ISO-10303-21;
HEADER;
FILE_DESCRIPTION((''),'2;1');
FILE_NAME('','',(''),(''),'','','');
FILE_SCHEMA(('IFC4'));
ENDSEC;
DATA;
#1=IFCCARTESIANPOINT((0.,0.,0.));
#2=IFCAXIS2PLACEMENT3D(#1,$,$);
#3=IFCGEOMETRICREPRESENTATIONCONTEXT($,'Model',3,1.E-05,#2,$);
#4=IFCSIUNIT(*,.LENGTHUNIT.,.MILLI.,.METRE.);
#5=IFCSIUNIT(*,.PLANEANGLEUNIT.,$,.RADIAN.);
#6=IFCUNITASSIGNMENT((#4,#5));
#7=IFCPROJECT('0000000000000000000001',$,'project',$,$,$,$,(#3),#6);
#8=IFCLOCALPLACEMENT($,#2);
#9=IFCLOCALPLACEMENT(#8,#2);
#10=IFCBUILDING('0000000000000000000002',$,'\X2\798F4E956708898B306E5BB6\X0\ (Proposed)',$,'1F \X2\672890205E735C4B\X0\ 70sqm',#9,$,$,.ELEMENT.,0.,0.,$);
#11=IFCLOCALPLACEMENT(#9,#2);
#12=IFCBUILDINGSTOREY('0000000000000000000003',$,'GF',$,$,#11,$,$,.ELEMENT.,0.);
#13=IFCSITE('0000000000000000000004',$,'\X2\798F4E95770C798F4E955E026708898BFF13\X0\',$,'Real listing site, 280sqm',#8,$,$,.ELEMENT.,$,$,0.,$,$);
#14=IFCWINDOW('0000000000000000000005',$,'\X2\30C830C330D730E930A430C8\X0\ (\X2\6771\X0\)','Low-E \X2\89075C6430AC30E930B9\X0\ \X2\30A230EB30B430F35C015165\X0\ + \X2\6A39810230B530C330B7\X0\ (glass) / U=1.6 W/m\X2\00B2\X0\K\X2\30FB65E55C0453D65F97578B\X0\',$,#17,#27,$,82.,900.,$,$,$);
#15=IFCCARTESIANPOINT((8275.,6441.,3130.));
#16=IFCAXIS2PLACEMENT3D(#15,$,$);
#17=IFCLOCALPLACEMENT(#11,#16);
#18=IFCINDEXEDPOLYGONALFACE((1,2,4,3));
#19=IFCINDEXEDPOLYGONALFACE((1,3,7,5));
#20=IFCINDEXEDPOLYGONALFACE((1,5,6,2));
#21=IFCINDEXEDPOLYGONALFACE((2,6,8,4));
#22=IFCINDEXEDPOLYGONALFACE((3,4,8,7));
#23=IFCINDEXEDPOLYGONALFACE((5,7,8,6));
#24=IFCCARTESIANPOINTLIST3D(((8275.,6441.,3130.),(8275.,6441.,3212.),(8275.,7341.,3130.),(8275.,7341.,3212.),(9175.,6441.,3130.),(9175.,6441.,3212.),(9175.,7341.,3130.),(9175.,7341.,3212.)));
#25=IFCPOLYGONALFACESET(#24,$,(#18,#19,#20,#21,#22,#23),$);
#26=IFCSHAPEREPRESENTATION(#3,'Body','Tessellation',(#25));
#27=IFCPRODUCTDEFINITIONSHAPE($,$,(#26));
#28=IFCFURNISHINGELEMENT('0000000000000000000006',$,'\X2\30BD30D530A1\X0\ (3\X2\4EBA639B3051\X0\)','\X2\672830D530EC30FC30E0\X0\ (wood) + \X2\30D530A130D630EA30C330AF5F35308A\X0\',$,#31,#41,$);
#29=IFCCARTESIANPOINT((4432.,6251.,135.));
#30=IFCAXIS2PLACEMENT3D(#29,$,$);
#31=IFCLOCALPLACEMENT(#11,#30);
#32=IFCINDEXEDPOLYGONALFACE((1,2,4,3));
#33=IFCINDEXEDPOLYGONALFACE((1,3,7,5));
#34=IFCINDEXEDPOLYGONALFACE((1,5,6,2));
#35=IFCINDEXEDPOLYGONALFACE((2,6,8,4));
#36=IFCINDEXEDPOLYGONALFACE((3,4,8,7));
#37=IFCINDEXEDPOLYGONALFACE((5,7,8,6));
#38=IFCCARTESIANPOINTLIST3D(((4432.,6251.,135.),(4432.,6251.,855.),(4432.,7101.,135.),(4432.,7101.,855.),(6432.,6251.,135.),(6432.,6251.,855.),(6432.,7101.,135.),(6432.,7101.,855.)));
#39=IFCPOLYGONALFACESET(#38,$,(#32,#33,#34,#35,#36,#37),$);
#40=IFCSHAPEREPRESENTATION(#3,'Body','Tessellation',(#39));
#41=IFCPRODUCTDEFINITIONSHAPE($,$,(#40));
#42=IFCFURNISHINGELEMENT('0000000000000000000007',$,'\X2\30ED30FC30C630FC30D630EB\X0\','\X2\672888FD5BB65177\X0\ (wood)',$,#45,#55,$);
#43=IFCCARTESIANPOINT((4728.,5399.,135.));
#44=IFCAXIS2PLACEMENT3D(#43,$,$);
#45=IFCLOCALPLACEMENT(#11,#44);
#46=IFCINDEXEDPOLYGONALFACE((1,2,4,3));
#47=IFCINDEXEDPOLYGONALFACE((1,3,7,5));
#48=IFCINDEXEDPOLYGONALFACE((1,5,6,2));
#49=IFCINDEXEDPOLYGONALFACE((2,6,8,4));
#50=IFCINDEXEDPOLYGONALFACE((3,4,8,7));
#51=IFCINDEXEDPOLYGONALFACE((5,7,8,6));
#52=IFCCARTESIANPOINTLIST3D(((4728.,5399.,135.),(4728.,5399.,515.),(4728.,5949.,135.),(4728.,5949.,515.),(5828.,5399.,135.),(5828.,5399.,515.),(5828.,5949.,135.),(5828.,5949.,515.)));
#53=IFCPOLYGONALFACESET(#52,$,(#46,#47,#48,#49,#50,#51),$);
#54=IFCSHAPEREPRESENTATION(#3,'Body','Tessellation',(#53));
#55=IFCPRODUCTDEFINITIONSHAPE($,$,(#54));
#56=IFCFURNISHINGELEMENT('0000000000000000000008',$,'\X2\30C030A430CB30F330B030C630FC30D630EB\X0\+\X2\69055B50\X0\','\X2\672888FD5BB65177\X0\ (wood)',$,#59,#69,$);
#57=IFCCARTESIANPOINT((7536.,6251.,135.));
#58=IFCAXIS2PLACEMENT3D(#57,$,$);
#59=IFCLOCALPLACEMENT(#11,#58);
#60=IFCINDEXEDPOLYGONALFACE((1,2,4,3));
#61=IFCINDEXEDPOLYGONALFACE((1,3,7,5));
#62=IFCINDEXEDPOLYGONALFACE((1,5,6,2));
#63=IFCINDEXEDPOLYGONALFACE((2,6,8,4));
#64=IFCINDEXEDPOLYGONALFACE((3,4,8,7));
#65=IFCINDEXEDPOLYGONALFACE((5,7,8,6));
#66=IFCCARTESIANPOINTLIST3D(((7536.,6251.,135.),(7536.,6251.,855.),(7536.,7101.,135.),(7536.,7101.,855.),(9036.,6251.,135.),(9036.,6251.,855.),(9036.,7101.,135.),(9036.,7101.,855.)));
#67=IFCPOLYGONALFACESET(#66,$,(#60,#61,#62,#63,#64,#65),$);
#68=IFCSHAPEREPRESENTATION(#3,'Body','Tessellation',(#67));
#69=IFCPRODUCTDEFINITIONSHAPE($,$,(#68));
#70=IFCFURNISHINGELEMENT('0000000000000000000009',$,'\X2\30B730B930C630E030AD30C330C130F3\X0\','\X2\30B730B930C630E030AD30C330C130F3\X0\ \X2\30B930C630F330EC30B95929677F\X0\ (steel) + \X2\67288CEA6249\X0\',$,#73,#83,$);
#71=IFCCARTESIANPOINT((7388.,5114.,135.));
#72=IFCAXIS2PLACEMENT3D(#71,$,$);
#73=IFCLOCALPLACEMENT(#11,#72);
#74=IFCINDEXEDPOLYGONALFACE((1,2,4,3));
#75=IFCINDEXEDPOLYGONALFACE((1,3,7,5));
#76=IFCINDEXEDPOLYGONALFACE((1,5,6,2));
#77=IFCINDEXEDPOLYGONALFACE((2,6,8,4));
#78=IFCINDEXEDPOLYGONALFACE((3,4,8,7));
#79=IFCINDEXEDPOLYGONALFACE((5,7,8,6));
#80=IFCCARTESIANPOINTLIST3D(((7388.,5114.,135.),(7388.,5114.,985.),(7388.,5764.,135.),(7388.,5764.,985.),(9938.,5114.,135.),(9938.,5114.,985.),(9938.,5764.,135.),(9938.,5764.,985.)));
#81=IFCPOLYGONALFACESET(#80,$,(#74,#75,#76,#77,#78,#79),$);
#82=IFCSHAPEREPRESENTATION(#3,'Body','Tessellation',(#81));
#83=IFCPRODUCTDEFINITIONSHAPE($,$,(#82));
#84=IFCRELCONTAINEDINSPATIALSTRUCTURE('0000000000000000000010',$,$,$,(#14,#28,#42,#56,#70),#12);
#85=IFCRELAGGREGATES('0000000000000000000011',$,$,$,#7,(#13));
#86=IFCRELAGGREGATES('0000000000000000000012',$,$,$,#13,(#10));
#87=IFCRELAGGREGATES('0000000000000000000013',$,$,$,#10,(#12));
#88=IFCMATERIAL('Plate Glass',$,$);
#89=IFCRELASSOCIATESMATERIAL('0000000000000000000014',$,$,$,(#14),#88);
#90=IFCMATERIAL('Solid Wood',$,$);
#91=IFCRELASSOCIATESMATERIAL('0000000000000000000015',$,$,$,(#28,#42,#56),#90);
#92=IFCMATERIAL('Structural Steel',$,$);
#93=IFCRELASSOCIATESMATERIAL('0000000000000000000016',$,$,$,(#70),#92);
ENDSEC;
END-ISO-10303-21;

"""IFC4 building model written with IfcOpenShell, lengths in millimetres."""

from ifc_helpers import new_model, si_unit, frame, frame_2d, origin, place, context, project, spatial, rectangle, extrude, material, element, save


model = new_model("IFC4")

# Units and contexts
model_context = context("Model", 3, precision=1e-05, world=origin())
ifc_project = project(units=[si_unit("LENGTHUNIT", "METRE", prefix="MILLI"), si_unit("PLANEANGLEUNIT", "RADIAN")], contexts=[model_context])

# Site, building, storey
site_placement = place(None, origin())
site = spatial("IfcSite", under=ifc_project, at=site_placement, Name="福井県福井市月見３", ObjectType="Real listing site, 280sqm", CompositionType="ELEMENT", RefElevation=0.0)
building_placement = place(site_placement, origin())
building = spatial("IfcBuilding", under=site, at=building_placement, Name="福井月見の家 (Proposed)", ObjectType="1F 木造平屋 70sqm", CompositionType="ELEMENT", ElevationOfRefHeight=0.0, ElevationOfTerrain=0.0)
storey_placement = place(building_placement, origin())
storey = spatial("IfcBuildingStorey", under=building, at=storey_placement, Name="GF", CompositionType="ELEMENT", Elevation=0.0)

# Shared definitions
ifc_material_1 = material(Name="Solid Wood")

# Shared definitions
ifc_material_2 = material(Name="Plate Glass")

# Window
window_1_placement = place(storey_placement, frame((8275.0, 6441.0, 3130.0)))
element("IfcWindow", 1, at=window_1_placement, inside=storey, material=ifc_material_2, Name="トップライト (東)", Description="Low-E 複層ガラス アルゴン封入 + 樹脂サッシ (glass) / U=1.6 W/m²K・日射取得型", OverallHeight=82.0, OverallWidth=900.0, context=model_context, shape_type="SweptSolid", body=[
    extrude(rectangle(XDim=900.0, YDim=900.0, at=frame_2d((450.0, 450.0))), frame((8275.0, 6441.0, 3130.0)), (0.0, 0.0, 1.0), 82.0),
])

# Shared definitions
ifc_material_3 = material(Name="Structural Steel")

# Furnishing elements
furnishing_1_placement = place(storey_placement, frame((4432.0, 6251.0, 135.0)))
element("IfcFurnishingElement", 2, at=furnishing_1_placement, inside=storey, material=ifc_material_1, Name="ソファ (3人掛け)", Description="木フレーム (wood) + ファブリック張り", context=model_context, shape_type="SweptSolid", body=[
    extrude(rectangle(XDim=2000.0, YDim=850.0, at=frame_2d((1000.0, 425.0))), frame((4432.0, 6251.0, 135.0)), (0.0, 0.0, 1.0), 720.0),
])
furnishing_2_placement = place(storey_placement, frame((4728.0, 5399.0, 135.0)))
element("IfcFurnishingElement", 3, at=furnishing_2_placement, inside=storey, material=ifc_material_1, Name="ローテーブル", Description="木製家具 (wood)", context=model_context, shape_type="SweptSolid", body=[
    extrude(rectangle(XDim=1100.0, YDim=550.0, at=frame_2d((550.0, 275.0))), frame((4728.0, 5399.0, 135.0)), (0.0, 0.0, 1.0), 380.0),
])
furnishing_3_placement = place(storey_placement, frame((7536.0, 6251.0, 135.0)))
element("IfcFurnishingElement", 4, at=furnishing_3_placement, inside=storey, material=ifc_material_1, Name="ダイニングテーブル+椅子", Description="木製家具 (wood)", context=model_context, shape_type="SweptSolid", body=[
    extrude(rectangle(XDim=1500.0, YDim=850.0, at=frame_2d((750.0, 425.0))), frame((7536.0, 6251.0, 135.0)), (0.0, 0.0, 1.0), 720.0),
])
furnishing_4_placement = place(storey_placement, frame((7388.0, 5114.0, 135.0)))
element("IfcFurnishingElement", 5, at=furnishing_4_placement, inside=storey, material=ifc_material_3, Name="システムキッチン", Description="システムキッチン ステンレス天板 (steel) + 木質扉", context=model_context, shape_type="SweptSolid", body=[
    extrude(rectangle(XDim=2550.0, YDim=650.0, at=frame_2d((1275.0, 325.0))), frame((7388.0, 5114.0, 135.0)), (0.0, 0.0, 1.0), 850.0),
])

save(model, "model.ifc")
